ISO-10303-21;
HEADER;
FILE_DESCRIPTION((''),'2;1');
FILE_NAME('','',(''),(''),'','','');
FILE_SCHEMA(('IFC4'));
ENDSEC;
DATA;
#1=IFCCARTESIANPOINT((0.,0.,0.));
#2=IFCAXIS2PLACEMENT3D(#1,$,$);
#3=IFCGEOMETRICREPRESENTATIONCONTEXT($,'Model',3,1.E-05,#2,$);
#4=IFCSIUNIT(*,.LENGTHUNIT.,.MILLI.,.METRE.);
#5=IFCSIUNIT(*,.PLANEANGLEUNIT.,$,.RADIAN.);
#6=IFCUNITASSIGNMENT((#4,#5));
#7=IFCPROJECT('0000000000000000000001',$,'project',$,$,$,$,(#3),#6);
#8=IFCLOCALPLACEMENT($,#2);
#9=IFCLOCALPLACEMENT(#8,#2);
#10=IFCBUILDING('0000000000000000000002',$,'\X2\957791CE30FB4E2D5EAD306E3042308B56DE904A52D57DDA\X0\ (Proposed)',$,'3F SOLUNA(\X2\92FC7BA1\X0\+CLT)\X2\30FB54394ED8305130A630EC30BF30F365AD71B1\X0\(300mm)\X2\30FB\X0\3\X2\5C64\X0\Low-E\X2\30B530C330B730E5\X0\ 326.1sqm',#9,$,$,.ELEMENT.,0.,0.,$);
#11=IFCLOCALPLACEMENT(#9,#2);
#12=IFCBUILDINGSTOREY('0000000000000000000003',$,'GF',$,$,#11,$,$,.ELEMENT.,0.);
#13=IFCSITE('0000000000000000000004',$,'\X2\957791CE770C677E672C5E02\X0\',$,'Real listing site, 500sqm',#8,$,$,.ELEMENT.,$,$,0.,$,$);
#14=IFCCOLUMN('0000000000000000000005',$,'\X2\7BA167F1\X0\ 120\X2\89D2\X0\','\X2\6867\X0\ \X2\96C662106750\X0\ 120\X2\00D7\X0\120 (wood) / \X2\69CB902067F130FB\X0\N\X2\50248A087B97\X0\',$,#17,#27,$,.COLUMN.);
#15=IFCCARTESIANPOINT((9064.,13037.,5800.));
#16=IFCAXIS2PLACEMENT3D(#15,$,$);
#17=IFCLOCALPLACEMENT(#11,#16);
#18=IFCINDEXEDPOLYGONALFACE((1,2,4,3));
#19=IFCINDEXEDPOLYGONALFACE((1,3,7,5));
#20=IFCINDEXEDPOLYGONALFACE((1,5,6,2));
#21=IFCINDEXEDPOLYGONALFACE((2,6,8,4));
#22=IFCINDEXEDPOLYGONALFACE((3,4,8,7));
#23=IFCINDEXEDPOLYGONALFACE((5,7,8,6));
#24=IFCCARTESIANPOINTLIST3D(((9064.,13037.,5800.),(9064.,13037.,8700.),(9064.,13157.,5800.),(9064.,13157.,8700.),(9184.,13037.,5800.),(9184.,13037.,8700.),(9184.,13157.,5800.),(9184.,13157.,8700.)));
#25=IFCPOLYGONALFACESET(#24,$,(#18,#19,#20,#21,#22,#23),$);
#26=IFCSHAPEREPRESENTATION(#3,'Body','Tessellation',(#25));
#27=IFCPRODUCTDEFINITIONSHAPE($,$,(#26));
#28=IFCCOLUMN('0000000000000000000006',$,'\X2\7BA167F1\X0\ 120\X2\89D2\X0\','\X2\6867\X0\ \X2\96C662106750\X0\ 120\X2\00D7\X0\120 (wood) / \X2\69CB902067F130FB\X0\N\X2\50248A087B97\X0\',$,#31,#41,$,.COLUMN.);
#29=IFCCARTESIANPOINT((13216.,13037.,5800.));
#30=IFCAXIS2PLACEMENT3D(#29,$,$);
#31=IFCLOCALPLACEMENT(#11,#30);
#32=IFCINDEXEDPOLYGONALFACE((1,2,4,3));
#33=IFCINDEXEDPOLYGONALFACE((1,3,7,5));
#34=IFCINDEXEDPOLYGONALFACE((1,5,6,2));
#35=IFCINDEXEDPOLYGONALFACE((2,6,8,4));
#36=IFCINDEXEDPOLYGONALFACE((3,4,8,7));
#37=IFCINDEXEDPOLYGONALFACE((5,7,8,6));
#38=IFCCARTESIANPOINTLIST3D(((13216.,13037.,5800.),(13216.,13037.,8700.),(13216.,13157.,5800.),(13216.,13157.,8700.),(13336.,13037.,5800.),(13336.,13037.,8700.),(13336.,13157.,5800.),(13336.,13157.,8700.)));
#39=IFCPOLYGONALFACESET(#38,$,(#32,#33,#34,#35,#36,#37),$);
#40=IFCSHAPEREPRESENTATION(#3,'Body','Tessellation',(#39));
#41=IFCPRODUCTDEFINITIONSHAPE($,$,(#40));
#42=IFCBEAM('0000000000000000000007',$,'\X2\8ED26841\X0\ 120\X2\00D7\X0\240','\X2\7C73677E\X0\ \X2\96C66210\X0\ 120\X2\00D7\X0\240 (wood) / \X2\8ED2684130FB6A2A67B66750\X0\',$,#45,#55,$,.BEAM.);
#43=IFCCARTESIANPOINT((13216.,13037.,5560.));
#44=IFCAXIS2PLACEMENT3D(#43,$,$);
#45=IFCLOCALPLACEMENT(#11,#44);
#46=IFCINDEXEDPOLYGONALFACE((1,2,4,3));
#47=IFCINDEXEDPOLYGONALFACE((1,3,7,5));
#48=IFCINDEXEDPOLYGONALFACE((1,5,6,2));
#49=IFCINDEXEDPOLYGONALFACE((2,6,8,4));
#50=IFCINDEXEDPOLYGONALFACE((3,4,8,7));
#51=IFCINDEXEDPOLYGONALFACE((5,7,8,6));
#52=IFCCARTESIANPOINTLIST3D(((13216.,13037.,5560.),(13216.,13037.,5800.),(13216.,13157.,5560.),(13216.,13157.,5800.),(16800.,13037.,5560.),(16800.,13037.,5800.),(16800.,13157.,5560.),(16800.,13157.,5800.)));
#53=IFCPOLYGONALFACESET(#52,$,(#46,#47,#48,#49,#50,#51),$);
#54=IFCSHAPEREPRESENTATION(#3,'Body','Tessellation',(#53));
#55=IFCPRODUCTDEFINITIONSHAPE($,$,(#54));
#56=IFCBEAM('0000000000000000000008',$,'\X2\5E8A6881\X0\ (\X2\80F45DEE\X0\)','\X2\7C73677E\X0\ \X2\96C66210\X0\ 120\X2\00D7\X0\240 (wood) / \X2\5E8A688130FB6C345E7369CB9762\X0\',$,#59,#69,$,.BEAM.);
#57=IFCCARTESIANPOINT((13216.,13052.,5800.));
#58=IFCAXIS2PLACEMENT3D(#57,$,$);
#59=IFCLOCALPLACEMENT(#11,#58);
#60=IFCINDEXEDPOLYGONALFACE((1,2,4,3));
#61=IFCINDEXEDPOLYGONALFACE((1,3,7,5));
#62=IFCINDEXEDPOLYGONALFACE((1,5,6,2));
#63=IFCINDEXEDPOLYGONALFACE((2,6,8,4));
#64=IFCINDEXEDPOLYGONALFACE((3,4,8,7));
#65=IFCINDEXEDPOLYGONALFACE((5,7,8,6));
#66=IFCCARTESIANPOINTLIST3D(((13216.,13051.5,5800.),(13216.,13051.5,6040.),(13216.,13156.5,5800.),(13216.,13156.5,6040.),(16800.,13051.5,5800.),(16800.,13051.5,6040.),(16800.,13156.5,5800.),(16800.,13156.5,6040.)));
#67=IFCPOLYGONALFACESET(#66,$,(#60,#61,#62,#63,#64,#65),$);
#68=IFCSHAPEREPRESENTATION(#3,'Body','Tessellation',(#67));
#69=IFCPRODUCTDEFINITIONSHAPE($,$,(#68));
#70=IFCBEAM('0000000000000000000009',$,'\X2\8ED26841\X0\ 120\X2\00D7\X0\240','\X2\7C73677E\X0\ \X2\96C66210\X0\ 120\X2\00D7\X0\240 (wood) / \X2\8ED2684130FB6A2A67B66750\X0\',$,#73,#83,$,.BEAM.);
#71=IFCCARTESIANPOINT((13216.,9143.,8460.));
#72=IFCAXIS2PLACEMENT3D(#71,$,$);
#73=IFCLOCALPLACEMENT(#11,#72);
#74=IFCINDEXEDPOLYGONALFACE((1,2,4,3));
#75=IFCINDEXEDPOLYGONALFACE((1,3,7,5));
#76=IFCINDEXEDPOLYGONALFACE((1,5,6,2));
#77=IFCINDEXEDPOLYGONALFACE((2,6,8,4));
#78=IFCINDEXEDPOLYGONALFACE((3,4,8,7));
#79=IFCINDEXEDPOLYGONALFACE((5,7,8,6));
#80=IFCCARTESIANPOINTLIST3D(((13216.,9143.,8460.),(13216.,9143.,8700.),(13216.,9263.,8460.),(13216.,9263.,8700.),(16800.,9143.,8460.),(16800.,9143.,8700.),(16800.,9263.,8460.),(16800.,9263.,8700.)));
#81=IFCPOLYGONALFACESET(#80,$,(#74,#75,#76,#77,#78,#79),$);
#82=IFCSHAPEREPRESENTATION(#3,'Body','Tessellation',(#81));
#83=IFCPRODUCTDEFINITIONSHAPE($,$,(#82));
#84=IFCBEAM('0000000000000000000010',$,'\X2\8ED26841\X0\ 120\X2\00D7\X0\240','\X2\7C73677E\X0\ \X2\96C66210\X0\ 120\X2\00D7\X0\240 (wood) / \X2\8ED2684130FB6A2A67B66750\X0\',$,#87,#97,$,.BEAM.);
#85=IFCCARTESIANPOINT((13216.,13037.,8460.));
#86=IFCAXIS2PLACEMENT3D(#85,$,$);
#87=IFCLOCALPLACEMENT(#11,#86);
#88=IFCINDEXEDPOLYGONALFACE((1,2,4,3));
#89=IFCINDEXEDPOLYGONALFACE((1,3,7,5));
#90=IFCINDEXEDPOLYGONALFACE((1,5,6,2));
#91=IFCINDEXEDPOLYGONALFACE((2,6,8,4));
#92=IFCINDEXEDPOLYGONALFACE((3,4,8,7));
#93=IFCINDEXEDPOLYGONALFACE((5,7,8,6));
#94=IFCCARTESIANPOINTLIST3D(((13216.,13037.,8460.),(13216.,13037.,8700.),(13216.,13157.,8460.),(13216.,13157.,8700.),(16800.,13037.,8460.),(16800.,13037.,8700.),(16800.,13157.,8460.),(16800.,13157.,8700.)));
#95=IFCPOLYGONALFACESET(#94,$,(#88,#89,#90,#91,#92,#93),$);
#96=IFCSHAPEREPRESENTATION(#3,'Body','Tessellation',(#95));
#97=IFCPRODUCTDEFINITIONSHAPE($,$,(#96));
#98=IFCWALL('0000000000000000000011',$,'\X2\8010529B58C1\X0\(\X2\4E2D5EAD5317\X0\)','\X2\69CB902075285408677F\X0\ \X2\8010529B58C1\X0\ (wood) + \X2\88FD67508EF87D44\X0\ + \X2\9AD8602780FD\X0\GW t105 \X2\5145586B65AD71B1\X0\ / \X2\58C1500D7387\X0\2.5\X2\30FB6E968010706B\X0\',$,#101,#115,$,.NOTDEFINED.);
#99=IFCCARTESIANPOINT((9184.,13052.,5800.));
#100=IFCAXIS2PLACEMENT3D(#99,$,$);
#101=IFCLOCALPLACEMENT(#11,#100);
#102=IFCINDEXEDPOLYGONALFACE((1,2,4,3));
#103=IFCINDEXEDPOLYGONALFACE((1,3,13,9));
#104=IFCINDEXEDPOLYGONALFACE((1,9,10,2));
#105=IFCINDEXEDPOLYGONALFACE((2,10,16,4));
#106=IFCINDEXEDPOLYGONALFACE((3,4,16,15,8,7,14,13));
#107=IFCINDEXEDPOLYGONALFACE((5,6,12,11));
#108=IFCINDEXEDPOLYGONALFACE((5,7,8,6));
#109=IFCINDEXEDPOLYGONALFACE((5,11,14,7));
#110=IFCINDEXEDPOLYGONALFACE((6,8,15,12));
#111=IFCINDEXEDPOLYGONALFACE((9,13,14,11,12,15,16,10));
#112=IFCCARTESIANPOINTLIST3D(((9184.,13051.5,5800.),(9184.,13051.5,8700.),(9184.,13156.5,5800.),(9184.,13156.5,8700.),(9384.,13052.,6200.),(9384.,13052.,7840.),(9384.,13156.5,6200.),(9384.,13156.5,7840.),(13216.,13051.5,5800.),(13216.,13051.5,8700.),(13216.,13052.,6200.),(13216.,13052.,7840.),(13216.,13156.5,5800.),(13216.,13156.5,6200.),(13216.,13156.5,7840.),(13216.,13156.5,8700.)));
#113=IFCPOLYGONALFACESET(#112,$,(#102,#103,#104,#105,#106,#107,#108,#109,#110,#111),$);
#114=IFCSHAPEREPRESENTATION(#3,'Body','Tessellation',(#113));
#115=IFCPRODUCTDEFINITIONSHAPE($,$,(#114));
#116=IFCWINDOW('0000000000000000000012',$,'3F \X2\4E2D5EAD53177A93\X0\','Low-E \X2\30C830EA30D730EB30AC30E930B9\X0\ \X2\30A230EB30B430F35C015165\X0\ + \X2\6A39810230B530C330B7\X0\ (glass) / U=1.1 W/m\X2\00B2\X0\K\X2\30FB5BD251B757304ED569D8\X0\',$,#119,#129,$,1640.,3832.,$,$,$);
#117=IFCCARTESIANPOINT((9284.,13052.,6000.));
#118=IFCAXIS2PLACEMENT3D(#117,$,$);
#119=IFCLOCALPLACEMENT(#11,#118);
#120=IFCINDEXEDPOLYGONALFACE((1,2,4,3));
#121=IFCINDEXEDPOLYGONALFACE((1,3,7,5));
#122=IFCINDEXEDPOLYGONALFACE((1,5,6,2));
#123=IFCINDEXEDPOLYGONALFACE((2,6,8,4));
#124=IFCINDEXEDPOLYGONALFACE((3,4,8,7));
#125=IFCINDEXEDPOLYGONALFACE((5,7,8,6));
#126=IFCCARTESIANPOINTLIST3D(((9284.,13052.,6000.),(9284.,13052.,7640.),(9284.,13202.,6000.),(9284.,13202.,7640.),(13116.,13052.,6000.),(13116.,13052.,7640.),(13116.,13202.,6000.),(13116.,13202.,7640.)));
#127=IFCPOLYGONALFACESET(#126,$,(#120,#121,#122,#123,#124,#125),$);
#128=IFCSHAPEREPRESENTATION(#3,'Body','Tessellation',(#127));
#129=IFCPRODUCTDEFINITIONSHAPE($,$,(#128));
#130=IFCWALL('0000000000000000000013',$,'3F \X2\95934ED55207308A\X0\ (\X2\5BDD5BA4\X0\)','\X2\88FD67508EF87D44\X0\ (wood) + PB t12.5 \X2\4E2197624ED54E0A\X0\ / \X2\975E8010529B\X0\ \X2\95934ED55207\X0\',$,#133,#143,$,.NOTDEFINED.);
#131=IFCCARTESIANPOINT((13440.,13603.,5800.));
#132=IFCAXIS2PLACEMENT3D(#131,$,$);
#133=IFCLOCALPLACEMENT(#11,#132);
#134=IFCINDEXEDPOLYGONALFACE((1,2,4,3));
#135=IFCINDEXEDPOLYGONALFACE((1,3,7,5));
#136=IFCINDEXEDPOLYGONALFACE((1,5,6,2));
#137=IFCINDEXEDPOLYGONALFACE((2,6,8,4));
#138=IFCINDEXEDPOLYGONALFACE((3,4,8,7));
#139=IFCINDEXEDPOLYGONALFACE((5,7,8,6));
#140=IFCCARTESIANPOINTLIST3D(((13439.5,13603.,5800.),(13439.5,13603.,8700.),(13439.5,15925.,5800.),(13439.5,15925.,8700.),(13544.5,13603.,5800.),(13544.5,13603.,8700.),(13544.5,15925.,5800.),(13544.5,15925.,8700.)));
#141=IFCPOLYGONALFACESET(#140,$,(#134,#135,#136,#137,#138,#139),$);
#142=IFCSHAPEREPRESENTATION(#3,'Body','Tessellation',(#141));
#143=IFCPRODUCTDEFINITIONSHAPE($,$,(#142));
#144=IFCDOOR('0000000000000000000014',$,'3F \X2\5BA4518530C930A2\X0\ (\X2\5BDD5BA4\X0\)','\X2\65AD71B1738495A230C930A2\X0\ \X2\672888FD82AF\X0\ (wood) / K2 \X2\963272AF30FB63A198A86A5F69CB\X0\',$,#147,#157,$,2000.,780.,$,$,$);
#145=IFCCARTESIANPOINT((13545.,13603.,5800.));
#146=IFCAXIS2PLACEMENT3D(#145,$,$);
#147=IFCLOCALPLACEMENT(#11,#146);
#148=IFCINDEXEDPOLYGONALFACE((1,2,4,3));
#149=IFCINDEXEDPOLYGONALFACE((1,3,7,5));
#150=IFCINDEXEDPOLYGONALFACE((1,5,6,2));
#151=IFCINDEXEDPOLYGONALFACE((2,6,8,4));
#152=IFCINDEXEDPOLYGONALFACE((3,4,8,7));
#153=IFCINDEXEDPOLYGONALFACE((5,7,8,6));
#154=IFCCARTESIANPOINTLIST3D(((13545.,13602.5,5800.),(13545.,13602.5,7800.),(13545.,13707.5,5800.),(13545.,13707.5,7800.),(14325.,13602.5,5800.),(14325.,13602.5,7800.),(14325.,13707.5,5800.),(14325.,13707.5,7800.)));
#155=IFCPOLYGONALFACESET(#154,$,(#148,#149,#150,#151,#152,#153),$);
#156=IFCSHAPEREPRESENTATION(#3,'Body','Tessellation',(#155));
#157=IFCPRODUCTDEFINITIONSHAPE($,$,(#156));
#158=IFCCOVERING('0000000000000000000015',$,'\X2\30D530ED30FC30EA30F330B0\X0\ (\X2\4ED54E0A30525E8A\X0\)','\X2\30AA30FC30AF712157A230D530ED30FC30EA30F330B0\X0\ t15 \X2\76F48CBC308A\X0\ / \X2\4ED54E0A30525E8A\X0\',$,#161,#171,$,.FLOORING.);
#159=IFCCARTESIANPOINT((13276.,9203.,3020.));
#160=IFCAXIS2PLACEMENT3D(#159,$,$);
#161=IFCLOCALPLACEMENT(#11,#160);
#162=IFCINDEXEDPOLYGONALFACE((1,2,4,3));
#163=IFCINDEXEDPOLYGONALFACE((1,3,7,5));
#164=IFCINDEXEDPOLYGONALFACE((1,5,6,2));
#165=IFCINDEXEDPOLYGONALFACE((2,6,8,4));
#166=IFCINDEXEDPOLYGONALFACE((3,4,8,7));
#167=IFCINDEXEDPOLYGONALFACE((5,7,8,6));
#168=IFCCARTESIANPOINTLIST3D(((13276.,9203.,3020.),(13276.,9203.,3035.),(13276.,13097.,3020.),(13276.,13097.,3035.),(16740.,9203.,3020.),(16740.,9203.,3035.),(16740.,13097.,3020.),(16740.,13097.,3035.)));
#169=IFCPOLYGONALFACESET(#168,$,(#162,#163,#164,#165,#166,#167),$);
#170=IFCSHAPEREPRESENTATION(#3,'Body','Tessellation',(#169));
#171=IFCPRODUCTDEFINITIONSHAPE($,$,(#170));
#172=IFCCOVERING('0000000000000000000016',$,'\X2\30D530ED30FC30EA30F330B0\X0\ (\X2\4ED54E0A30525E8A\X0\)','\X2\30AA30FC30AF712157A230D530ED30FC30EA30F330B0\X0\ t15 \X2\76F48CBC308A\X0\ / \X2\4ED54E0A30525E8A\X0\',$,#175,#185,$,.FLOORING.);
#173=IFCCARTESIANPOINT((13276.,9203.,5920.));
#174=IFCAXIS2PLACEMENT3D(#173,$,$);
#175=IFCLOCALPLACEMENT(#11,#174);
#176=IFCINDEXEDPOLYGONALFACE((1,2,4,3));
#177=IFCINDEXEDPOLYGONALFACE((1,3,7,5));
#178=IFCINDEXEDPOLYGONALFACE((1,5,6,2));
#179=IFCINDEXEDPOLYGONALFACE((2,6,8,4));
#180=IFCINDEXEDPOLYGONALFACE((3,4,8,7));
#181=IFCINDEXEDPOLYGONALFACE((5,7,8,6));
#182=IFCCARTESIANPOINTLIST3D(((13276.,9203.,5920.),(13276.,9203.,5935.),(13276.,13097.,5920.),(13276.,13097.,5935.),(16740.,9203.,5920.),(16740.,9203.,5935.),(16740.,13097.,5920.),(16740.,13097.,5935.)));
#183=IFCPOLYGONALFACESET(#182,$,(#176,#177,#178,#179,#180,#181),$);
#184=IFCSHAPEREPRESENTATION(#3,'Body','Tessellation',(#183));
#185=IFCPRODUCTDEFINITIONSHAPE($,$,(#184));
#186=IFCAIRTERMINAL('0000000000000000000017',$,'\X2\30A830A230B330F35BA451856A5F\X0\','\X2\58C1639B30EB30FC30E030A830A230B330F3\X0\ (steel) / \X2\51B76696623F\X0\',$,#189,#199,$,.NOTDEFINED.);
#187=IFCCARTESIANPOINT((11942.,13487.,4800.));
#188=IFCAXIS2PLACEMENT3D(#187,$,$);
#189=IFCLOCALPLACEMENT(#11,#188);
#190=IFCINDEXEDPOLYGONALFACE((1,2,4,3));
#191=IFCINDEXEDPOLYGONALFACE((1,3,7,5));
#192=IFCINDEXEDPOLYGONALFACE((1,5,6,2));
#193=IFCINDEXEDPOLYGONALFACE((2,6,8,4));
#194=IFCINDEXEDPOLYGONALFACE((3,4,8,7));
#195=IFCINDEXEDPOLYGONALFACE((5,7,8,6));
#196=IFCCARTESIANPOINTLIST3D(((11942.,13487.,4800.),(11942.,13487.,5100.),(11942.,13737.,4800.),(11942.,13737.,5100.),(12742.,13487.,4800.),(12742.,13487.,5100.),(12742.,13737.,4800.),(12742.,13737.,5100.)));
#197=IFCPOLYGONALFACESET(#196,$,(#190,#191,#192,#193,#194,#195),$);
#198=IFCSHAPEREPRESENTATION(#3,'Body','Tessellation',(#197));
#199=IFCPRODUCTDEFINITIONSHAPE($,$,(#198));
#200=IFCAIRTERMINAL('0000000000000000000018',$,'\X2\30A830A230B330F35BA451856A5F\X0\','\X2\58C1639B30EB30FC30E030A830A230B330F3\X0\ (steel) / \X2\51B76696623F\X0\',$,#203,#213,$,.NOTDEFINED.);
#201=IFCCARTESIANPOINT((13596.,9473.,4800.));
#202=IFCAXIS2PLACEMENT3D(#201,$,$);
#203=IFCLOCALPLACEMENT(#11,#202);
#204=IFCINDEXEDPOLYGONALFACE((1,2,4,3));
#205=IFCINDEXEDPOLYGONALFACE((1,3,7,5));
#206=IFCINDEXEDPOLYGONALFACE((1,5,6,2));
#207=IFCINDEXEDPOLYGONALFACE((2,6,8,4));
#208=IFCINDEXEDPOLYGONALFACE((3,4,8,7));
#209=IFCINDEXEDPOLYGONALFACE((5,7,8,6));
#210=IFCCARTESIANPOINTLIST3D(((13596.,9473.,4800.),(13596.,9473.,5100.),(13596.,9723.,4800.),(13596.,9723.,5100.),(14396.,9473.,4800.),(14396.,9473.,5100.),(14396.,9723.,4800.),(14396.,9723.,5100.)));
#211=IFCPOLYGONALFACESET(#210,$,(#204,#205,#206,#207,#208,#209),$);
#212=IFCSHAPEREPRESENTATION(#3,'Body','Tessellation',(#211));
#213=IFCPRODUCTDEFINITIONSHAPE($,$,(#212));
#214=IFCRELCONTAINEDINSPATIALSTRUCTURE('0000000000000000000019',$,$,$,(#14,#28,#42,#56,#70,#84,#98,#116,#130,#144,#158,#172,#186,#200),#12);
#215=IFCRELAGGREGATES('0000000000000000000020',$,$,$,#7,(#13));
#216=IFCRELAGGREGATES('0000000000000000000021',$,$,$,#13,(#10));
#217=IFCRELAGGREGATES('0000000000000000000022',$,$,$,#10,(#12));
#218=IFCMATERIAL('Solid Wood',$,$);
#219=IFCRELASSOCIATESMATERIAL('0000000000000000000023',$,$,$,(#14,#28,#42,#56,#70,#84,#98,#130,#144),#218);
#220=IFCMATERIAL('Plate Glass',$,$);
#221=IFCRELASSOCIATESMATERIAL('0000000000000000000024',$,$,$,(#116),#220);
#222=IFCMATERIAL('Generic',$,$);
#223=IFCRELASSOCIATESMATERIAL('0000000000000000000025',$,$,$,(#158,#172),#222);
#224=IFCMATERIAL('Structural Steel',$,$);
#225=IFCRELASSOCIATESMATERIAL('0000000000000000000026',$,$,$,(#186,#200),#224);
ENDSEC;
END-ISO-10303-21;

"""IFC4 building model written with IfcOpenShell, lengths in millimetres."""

from ifc_helpers import new_model, si_unit, frame, frame_2d, origin, place, context, project, spatial, rectangle, extrude, material, element, fill, save


model = new_model("IFC4")

# Units and contexts
model_context = context("Model", 3, precision=1e-05, world=origin())
ifc_project = project(units=[si_unit("LENGTHUNIT", "METRE", prefix="MILLI"), si_unit("PLANEANGLEUNIT", "RADIAN")], contexts=[model_context])

# Site, building, storey
site_placement = place(None, origin())
site = spatial("IfcSite", under=ifc_project, at=site_placement, Name="長野県松本市", ObjectType="Real listing site, 500sqm", CompositionType="ELEMENT", RefElevation=0.0)
building_placement = place(site_placement, origin())
building = spatial("IfcBuilding", under=site, at=building_placement, Name="長野・中庭のある回遊動線 (Proposed)", ObjectType="3F SOLUNA(鋼管+CLT)・吹付けウレタン断熱(300mm)・3層Low-Eサッシュ 326.1sqm", CompositionType="ELEMENT", ElevationOfRefHeight=0.0, ElevationOfTerrain=0.0)
storey_placement = place(building_placement, origin())
storey = spatial("IfcBuildingStorey", under=building, at=storey_placement, Name="GF", CompositionType="ELEMENT", Elevation=0.0)

# Columns
ifc_material_1 = material(Name="Solid Wood")
column_1_placement = place(storey_placement, frame((9064.0, 13037.0, 5800.0)))
element("IfcColumn", 1, at=column_1_placement, inside=storey, material=ifc_material_1, Name="管柱 120角", Description="桧 集成材 120×120 (wood) / 構造柱・N値計算", PredefinedType="COLUMN", context=model_context, shape_type="SweptSolid", body=[
    extrude(rectangle(XDim=120.0, YDim=120.0, at=frame_2d((60.0, 60.0))), frame((9064.0, 13037.0, 5800.0)), (0.0, 0.0, 1.0), 2900.0),
])
column_2_placement = place(storey_placement, frame((13216.0, 13037.0, 5800.0)))
element("IfcColumn", 2, at=column_2_placement, inside=storey, material=ifc_material_1, Name="管柱 120角", Description="桧 集成材 120×120 (wood) / 構造柱・N値計算", PredefinedType="COLUMN", context=model_context, shape_type="SweptSolid", body=[
    extrude(rectangle(XDim=120.0, YDim=120.0, at=frame_2d((60.0, 60.0))), frame((13216.0, 13037.0, 5800.0)), (0.0, 0.0, 1.0), 2900.0),
])

# Beams
beam_1_placement = place(storey_placement, frame((13216.0, 13037.0, 5560.0)))
element("IfcBeam", 3, at=beam_1_placement, inside=storey, material=ifc_material_1, Name="軒桁 120×240", Description="米松 集成 120×240 (wood) / 軒桁・横架材", PredefinedType="BEAM", context=model_context, shape_type="SweptSolid", body=[
    extrude(rectangle(XDim=3584.0, YDim=120.0, at=frame_2d((1792.0, 60.0))), frame((13216.0, 13037.0, 5560.0)), (0.0, 0.0, 1.0), 240.0),
])
beam_2_placement = place(storey_placement, frame((13216.0, 13052.0, 5800.0)))
element("IfcBeam", 4, at=beam_2_placement, inside=storey, material=ifc_material_1, Name="床梁 (胴差)", Description="米松 集成 120×240 (wood) / 床梁・水平構面", PredefinedType="BEAM", context=model_context, shape_type="SweptSolid", body=[
    extrude(rectangle(XDim=3584.0, YDim=105.0, at=frame_2d((1792.0, 52.0))), frame((13216.0, 13052.0, 5800.0)), (0.0, 0.0, 1.0), 240.0),
])
beam_3_placement = place(storey_placement, frame((13216.0, 9143.0, 8460.0)))
element("IfcBeam", 5, at=beam_3_placement, inside=storey, material=ifc_material_1, Name="軒桁 120×240", Description="米松 集成 120×240 (wood) / 軒桁・横架材", PredefinedType="BEAM", context=model_context, shape_type="SweptSolid", body=[
    extrude(rectangle(XDim=3584.0, YDim=120.0, at=frame_2d((1792.0, 60.0))), frame((13216.0, 9143.0, 8460.0)), (0.0, 0.0, 1.0), 240.0),
])
beam_4_placement = place(storey_placement, frame((13216.0, 13037.0, 8460.0)))
element("IfcBeam", 6, at=beam_4_placement, inside=storey, material=ifc_material_1, Name="軒桁 120×240", Description="米松 集成 120×240 (wood) / 軒桁・横架材", PredefinedType="BEAM", context=model_context, shape_type="SweptSolid", body=[
    extrude(rectangle(XDim=3584.0, YDim=120.0, at=frame_2d((1792.0, 60.0))), frame((13216.0, 13037.0, 8460.0)), (0.0, 0.0, 1.0), 240.0),
])

# Wall, opening, window
wall_1_placement = place(storey_placement, frame((9184.0, 13052.0, 5800.0)))
wall_1 = element("IfcWall", 7, at=wall_1_placement, inside=storey, material=ifc_material_1, Name="耐力壁(中庭北)", Description="構造用合板 耐力壁 (wood) + 製材軸組 + 高性能GW t105 充填断熱 / 壁倍率2.5・準耐火", PredefinedType="NOTDEFINED", context=model_context, shape_type="SweptSolid", body=[
    extrude(rectangle(XDim=4032.0, YDim=105.0, at=frame_2d((2016.0, 52.0))), frame((9184.0, 13052.0, 5800.0)), (0.0, 0.0, 1.0), 2900.0),
])
opening_placement = place(storey_placement, frame((9284.0, 13052.0, 6000.0)))
opening = element("IfcOpeningElement", 8, at=opening_placement, cuts=wall_1, PredefinedType="NOTDEFINED", context=model_context, shape_type="SweptSolid", body=[
    extrude(rectangle(XDim=3832.0, YDim=150.0, at=frame_2d((1916.0, 75.0))), frame((9284.0, 13052.0, 6000.0)), (0.0, 0.0, 1.0), 1640.0),
])
ifc_material_2 = material(Name="Plate Glass")
window_placement = place(storey_placement, frame((9284.0, 13052.0, 6000.0)))
window = element("IfcWindow", 9, at=window_placement, inside=storey, material=ifc_material_2, Name="3F 中庭北窓", Description="Low-E トリプルガラス アルゴン封入 + 樹脂サッシ (glass) / U=1.1 W/m²K・寒冷地仕様", OverallHeight=1640.0, OverallWidth=3832.0, context=model_context, shape_type="SweptSolid", body=[
    extrude(rectangle(XDim=3832.0, YDim=150.0, at=frame_2d((1916.0, 75.0))), frame((9284.0, 13052.0, 6000.0)), (0.0, 0.0, 1.0), 1640.0),
])
fill(opening, window)

# Wall
wall_2_placement = place(storey_placement, frame((13440.0, 13603.0, 5800.0)))
element("IfcWall", 10, at=wall_2_placement, inside=storey, material=ifc_material_1, Name="3F 間仕切り (寝室)", Description="製材軸組 (wood) + PB t12.5 両面仕上 / 非耐力 間仕切", PredefinedType="NOTDEFINED", context=model_context, shape_type="SweptSolid", body=[
    extrude(rectangle(XDim=105.0, YDim=2322.0, at=frame_2d((52.0, 1161.0))), frame((13440.0, 13603.0, 5800.0)), (0.0, 0.0, 1.0), 2900.0),
])

# Door
door_placement = place(storey_placement, frame((13545.0, 13603.0, 5800.0)))
element("IfcDoor", 11, at=door_placement, inside=storey, material=ifc_material_1, Name="3F 室内ドア (寝室)", Description="断熱玄関ドア 木製芯 (wood) / K2 防犯・採風機構", OverallHeight=2000.0, OverallWidth=780.0, context=model_context, shape_type="SweptSolid", body=[
    extrude(rectangle(XDim=780.0, YDim=105.0, at=frame_2d((390.0, 52.0))), frame((13545.0, 13603.0, 5800.0)), (0.0, 0.0, 1.0), 2000.0),
])

# Coverings
ifc_material_3 = material(Name="Generic")
covering_1_placement = place(storey_placement, frame((13276.0, 9203.0, 3020.0)))
element("IfcCovering", 12, at=covering_1_placement, inside=storey, material=ifc_material_3, Name="フローリング (仕上げ床)", Description="オーク無垢フローリング t15 直貼り / 仕上げ床", PredefinedType="FLOORING", context=model_context, shape_type="SweptSolid", body=[
    extrude(rectangle(XDim=3464.0, YDim=3894.0, at=frame_2d((1732.0, 1947.0))), frame((13276.0, 9203.0, 3020.0)), (0.0, 0.0, 1.0), 15.0),
])
covering_2_placement = place(storey_placement, frame((13276.0, 9203.0, 5920.0)))
element("IfcCovering", 13, at=covering_2_placement, inside=storey, material=ifc_material_3, Name="フローリング (仕上げ床)", Description="オーク無垢フローリング t15 直貼り / 仕上げ床", PredefinedType="FLOORING", context=model_context, shape_type="SweptSolid", body=[
    extrude(rectangle(XDim=3464.0, YDim=3894.0, at=frame_2d((1732.0, 1947.0))), frame((13276.0, 9203.0, 5920.0)), (0.0, 0.0, 1.0), 15.0),
])

# Air terminals
ifc_material_4 = material(Name="Structural Steel")
air_terminal_1_placement = place(storey_placement, frame((11942.0, 13487.0, 4800.0)))
element("IfcAirTerminal", 14, at=air_terminal_1_placement, inside=storey, material=ifc_material_4, Name="エアコン室内機", Description="壁掛ルームエアコン (steel) / 冷暖房", PredefinedType="NOTDEFINED", context=model_context, shape_type="SweptSolid", body=[
    extrude(rectangle(XDim=800.0, YDim=250.0, at=frame_2d((400.0, 125.0))), frame((11942.0, 13487.0, 4800.0)), (0.0, 0.0, 1.0), 300.0),
])
air_terminal_2_placement = place(storey_placement, frame((13596.0, 9473.0, 4800.0)))
element("IfcAirTerminal", 15, at=air_terminal_2_placement, inside=storey, material=ifc_material_4, Name="エアコン室内機", Description="壁掛ルームエアコン (steel) / 冷暖房", PredefinedType="NOTDEFINED", context=model_context, shape_type="SweptSolid", body=[
    extrude(rectangle(XDim=800.0, YDim=250.0, at=frame_2d((400.0, 125.0))), frame((13596.0, 9473.0, 4800.0)), (0.0, 0.0, 1.0), 300.0),
])

save(model, "model.ifc")
